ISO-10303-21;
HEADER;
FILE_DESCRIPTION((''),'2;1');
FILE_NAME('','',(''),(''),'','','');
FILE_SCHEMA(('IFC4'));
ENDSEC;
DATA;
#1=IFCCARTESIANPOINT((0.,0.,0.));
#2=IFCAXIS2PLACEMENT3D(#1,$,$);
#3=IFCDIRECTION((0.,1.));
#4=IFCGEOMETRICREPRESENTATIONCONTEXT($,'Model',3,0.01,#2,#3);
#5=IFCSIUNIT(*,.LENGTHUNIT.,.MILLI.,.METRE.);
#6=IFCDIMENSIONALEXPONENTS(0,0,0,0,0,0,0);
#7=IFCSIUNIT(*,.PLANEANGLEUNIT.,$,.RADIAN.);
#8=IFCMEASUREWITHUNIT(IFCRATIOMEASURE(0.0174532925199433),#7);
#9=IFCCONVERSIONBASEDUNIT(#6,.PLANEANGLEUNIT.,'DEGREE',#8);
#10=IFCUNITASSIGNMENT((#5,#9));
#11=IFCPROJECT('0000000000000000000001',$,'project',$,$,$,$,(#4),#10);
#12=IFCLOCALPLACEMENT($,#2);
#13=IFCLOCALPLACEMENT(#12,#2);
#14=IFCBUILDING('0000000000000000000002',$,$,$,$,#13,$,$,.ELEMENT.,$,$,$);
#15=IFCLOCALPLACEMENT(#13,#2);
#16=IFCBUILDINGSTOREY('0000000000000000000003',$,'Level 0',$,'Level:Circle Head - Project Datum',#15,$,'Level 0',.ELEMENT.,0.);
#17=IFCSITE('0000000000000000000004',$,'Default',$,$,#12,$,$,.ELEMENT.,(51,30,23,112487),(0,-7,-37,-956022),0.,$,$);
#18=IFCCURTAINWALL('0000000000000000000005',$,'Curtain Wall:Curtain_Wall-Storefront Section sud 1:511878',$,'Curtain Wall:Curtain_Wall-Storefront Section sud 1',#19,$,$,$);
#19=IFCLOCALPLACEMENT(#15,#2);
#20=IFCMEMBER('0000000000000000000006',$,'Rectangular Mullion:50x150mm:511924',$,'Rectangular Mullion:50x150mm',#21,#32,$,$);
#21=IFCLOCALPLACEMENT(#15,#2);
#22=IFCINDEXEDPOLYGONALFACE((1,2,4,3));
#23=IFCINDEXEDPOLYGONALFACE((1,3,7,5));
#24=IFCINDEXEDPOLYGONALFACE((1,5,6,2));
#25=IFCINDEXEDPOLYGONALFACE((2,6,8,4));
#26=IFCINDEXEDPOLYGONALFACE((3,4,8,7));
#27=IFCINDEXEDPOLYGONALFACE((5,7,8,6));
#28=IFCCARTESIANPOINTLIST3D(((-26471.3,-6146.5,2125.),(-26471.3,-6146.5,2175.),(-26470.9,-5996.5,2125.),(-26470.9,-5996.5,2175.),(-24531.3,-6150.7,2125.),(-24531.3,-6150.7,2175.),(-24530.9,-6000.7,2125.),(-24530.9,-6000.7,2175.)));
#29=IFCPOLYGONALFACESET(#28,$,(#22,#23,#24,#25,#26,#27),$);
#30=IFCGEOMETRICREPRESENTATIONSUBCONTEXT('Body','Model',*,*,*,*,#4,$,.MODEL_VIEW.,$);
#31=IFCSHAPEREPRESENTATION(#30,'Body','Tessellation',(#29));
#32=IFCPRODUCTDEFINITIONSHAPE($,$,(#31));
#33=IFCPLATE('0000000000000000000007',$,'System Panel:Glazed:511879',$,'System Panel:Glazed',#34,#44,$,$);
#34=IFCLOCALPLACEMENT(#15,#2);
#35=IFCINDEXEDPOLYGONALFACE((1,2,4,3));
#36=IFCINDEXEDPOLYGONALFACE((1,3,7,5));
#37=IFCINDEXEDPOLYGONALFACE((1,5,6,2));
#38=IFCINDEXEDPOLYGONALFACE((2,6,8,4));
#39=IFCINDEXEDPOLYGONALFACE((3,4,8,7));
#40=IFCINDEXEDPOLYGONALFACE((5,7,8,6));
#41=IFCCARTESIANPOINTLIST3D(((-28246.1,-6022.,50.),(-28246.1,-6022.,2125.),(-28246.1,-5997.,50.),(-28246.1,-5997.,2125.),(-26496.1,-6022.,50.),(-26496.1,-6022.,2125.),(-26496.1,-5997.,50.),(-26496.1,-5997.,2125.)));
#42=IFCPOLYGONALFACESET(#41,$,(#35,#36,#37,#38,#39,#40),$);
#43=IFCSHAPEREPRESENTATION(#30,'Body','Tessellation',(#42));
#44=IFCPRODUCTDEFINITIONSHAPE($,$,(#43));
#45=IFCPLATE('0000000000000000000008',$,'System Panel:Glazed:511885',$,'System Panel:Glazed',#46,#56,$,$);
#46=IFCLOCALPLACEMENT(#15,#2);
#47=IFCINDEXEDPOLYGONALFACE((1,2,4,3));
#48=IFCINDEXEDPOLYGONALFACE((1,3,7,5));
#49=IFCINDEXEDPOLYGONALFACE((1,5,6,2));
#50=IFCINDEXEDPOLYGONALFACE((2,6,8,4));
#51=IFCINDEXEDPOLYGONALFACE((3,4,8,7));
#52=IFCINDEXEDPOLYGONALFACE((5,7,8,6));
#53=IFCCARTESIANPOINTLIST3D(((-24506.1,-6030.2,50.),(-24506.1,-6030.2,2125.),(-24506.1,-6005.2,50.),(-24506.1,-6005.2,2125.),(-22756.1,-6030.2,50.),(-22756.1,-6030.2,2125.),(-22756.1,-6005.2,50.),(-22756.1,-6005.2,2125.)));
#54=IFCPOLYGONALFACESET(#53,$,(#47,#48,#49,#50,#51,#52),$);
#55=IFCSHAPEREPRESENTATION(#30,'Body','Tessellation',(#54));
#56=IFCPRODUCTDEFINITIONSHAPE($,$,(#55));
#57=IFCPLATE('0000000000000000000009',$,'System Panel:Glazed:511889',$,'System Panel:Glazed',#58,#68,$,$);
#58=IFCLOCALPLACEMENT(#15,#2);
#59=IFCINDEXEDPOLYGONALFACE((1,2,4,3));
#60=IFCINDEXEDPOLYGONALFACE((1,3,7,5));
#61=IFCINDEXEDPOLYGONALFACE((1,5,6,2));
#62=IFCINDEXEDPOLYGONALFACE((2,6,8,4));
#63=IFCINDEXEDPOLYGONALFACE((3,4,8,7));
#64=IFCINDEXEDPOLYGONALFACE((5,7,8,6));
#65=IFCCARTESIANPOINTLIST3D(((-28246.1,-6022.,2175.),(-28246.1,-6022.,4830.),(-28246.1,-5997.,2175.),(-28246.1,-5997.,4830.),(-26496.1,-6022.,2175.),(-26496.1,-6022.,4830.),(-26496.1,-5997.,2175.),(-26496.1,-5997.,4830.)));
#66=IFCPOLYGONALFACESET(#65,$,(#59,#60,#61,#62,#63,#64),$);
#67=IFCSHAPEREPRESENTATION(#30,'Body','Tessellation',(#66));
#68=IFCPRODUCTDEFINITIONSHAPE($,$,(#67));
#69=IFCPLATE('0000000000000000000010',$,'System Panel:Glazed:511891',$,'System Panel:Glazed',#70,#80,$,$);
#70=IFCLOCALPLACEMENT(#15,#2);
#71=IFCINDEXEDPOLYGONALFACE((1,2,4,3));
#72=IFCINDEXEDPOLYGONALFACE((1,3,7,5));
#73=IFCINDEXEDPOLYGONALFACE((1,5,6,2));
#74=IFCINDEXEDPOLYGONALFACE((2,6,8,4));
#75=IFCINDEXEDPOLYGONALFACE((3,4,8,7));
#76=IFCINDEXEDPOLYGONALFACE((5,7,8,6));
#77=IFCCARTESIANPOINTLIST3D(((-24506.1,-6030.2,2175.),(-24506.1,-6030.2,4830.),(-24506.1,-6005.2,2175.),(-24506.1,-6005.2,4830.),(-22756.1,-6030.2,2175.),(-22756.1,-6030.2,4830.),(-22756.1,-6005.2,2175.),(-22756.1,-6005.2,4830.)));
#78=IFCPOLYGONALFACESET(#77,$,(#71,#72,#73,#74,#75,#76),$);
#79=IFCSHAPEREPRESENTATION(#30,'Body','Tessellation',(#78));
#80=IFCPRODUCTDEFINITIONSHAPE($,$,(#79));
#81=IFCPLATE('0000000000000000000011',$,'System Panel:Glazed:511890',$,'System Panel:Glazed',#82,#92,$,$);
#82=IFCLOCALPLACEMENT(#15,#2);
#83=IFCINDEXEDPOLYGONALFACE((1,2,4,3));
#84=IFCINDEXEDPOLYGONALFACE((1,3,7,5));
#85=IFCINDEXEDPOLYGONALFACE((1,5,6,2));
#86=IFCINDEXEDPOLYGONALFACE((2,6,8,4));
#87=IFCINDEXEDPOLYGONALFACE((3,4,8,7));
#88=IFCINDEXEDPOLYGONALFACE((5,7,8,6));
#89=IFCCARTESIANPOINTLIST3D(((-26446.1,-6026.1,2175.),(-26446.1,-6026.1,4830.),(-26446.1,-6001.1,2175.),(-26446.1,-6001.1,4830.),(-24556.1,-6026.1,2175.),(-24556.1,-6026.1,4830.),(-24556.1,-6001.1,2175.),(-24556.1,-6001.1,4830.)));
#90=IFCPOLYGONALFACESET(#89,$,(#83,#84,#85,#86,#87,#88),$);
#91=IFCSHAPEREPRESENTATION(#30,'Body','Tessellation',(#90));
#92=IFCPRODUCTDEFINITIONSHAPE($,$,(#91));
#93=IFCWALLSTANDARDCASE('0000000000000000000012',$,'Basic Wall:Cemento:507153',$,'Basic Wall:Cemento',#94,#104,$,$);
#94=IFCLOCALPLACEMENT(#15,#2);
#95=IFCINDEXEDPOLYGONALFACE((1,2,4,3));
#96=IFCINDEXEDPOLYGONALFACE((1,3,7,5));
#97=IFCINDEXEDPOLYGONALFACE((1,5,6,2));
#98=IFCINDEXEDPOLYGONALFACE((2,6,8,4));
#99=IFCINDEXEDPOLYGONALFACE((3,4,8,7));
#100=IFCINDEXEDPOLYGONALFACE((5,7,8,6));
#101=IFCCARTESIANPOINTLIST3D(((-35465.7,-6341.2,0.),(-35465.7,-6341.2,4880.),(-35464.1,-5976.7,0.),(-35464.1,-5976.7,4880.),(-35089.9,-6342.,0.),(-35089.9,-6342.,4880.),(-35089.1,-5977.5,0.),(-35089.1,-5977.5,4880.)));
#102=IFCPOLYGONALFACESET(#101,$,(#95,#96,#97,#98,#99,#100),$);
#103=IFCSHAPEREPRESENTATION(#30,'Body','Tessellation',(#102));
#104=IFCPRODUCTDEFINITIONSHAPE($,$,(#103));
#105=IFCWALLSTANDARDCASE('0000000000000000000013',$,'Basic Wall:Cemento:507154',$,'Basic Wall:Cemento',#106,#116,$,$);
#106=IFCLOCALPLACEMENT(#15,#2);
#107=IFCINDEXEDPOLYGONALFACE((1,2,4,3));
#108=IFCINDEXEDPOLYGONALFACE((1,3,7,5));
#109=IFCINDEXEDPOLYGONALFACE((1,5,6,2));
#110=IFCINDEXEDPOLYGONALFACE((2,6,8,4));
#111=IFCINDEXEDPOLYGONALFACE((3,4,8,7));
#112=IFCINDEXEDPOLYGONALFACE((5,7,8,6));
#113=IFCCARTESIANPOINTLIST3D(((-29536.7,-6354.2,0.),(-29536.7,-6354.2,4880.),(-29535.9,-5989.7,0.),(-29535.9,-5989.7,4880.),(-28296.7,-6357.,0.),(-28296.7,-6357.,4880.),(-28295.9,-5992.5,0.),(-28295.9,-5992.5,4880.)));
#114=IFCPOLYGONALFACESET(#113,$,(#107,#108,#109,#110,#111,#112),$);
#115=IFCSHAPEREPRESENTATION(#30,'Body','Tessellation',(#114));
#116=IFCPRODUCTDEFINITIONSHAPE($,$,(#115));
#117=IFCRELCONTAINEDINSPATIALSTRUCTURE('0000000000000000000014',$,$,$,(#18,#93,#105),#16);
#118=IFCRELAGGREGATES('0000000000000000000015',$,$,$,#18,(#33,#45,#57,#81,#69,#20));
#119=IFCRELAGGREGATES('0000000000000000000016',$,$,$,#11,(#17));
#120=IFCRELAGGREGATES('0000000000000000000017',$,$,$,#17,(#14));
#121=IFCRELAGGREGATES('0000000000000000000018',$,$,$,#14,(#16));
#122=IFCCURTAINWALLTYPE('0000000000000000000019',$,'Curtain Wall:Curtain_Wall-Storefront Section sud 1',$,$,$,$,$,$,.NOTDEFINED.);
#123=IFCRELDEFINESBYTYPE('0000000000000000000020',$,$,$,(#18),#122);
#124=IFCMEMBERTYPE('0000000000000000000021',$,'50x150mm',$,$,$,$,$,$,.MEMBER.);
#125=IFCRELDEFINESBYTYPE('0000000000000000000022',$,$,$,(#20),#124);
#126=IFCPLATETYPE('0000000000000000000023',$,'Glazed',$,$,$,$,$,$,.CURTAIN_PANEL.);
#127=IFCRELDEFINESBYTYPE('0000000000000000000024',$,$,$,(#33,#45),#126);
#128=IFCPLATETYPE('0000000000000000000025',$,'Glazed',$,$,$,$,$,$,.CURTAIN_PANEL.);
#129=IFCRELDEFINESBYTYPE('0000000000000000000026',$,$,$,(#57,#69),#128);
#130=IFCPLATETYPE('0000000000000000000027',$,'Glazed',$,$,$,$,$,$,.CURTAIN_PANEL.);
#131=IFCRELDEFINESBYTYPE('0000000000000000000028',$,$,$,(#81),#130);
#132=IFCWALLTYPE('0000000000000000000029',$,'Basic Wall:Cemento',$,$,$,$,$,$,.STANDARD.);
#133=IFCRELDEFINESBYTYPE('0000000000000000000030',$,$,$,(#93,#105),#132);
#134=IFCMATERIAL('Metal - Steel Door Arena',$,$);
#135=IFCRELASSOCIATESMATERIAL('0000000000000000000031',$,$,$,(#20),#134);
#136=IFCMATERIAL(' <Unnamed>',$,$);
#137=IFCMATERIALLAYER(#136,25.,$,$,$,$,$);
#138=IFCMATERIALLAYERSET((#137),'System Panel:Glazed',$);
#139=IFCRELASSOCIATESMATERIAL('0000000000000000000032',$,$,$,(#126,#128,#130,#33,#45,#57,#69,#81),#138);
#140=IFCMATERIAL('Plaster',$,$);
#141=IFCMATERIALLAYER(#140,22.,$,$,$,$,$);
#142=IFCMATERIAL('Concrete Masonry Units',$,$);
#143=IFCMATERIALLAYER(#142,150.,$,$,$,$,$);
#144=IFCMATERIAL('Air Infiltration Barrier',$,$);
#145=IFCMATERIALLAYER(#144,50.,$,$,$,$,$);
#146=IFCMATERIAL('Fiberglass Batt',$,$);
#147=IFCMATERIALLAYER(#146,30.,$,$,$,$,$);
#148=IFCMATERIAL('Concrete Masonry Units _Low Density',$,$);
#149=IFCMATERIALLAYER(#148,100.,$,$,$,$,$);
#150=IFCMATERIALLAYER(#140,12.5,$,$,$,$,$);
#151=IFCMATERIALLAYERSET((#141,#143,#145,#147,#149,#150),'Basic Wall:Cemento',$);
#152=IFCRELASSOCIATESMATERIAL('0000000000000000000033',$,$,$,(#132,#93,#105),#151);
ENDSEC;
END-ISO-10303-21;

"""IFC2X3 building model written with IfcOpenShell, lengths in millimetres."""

from ifc_helpers import new_model, entity, si_unit, converted_unit, direction, frame, frame_2d, origin, origin_2d_with_axis, place, context, subcontext, project, spatial, polyline, rectangle, outline, extrude, source, transform, mapped, material, layer, layer_set, layer_usage, type_object, type_shapes, element, aggregate, save


model = new_model("IFC2X3")

# Units and contexts
model_context = context("Model", 3, precision=0.01, world=origin(), true_north=direction((0.0, 1.0)))
body_context = subcontext(model_context, "Body", "Model", "MODEL_VIEW")
ifc_project = project(units=[si_unit("LENGTHUNIT", "METRE", prefix="MILLI"), converted_unit("PLANEANGLEUNIT", "DEGREE", entity("IfcRatioMeasure", 0.0174532925199433), si_unit("PLANEANGLEUNIT", "RADIAN"), dimensions=[0, 0, 0, 0, 0, 0, 0])], contexts=[model_context])

# Site, building, storey
site_placement = place(None, origin())
site = spatial("IfcSite", under=ifc_project, at=site_placement, Name="Default", CompositionType="ELEMENT", RefLatitude=(51, 30, 23, 112487), RefLongitude=(0, -7, -37, -956022), RefElevation=0.0)
building_placement = place(site_placement, origin())
building = spatial("IfcBuilding", under=site, at=building_placement, CompositionType="ELEMENT")
storey_placement = place(building_placement, origin())
storey = spatial("IfcBuildingStorey", under=building, at=storey_placement, Name="Level 0", ObjectType="Level:Circle Head - Project Datum", LongName="Level 0", CompositionType="ELEMENT", Elevation=0.0)

# Shared definitions
curtain_wall_type = type_object("IfcCurtainWallType", Name="Curtain Wall:Curtain_Wall-Storefront Section sud 1", PredefinedType="NOTDEFINED")
ifc_material_1 = material(Name="Metal - Steel Door Arena")

# Curtain wall, member, plates
curtain_wall_1_placement = place(storey_placement, origin())
curtain_wall_1 = element("IfcCurtainWall", 1, at=curtain_wall_1_placement, inside=storey, type_object=curtain_wall_type, Name="Curtain Wall:Curtain_Wall-Storefront Section sud 1:511878", ObjectType="Curtain Wall:Curtain_Wall-Storefront Section sud 1")
member_type_1 = type_object("IfcMemberType", Name="50x150mm", PredefinedType="MEMBER")
shared_shape_1 = source(origin(), body_context, "Body", "SweptSolid", [
    extrude(rectangle(XDim=150.0, YDim=50.0, at=origin_2d_with_axis()), frame((0.0, 0.0, -1940.0), z_axis=(0.0, 0.0, 1.0), x_axis=(0.0, -1.0, 0.0)), (0.0, 0.0, 1.0), 1940.0),
])
type_shapes(member_type_1, [shared_shape_1])
member_1_placement = place(storey_placement, frame((-24531.1, -6075.7, 2150.0), z_axis=(0.999998, -0.002199, 0.0), x_axis=(0.0, 0.0, 1.0)))
member_1 = element("IfcMember", 2, at=member_1_placement, type_object=member_type_1, material=ifc_material_1, Name="Rectangular Mullion:50x150mm:511924", ObjectType="Rectangular Mullion:50x150mm", context=body_context, shape_type="MappedRepresentation", body=[
    mapped(shared_shape_1, transform((0.0, 0.0, 0.0), scale=1.0)),
])
ifc_material_2 = material(Name=" <Unnamed>")
ifc_layer_1 = layer(ifc_material_2, 25.0)
ifc_layer_set_1 = layer_set([ifc_layer_1], Name="System Panel:Glazed")
ifc_layer_usage_1 = layer_usage(ifc_layer_set_1, "AXIS3", "POSITIVE", 0.2)
plate_type_1 = type_object("IfcPlateType", Name="Glazed", PredefinedType="CURTAIN_PANEL", material=ifc_layer_set_1)
shared_shape_2 = source(origin(), body_context, "Body", "SweptSolid", [
    extrude(rectangle(XDim=25.0, YDim=1750.0, at=origin_2d_with_axis()), frame((0.0, 60.0, 0.0), z_axis=(0.0, 0.0, 1.0), x_axis=(0.0, 1.0, 0.0)), (0.0, 0.0, 1.0), 2075.0),
])
type_shapes(plate_type_1, [shared_shape_2])
plate_1_placement = place(curtain_wall_1_placement, frame((-27371.1, -6069.5, 50.0)))
plate_1 = element("IfcPlate", 3, at=plate_1_placement, type_object=plate_type_1, material=ifc_layer_usage_1, Name="System Panel:Glazed:511879", ObjectType="System Panel:Glazed", context=body_context, shape_type="MappedRepresentation", body=[
    mapped(shared_shape_2, transform((0.0, 0.0, 0.0), scale=1.0)),
])
ifc_layer_usage_2 = layer_usage(ifc_layer_set_1, "AXIS3", "POSITIVE", 0.2)
plate_2_placement = place(curtain_wall_1_placement, frame((-23631.1, -6077.7, 50.0)))
plate_2 = element("IfcPlate", 4, at=plate_2_placement, type_object=plate_type_1, material=ifc_layer_usage_2, Name="System Panel:Glazed:511885", ObjectType="System Panel:Glazed", context=body_context, shape_type="MappedRepresentation", body=[
    mapped(shared_shape_2, transform((0.0, 0.0, 0.0), scale=1.0)),
])
ifc_layer_usage_3 = layer_usage(ifc_layer_set_1, "AXIS3", "POSITIVE", 0.2)
plate_type_2 = type_object("IfcPlateType", Name="Glazed", PredefinedType="CURTAIN_PANEL", material=ifc_layer_set_1)
shared_shape_3 = source(origin(), body_context, "Body", "SweptSolid", [
    extrude(rectangle(XDim=25.0, YDim=1750.0, at=frame_2d((0.0, 0.0), x_axis=(1.0, 0.0))), frame((0.0, 60.0, 0.0), z_axis=(0.0, 0.0, 1.0), x_axis=(0.0, 1.0, 0.0)), (0.0, 0.0, 1.0), 2655.0),
])
type_shapes(plate_type_2, [shared_shape_3])
plate_3_placement = place(curtain_wall_1_placement, frame((-27371.1, -6069.5, 2175.0)))
plate_3 = element("IfcPlate", 5, at=plate_3_placement, type_object=plate_type_2, material=ifc_layer_usage_3, Name="System Panel:Glazed:511889", ObjectType="System Panel:Glazed", context=body_context, shape_type="MappedRepresentation", body=[
    mapped(shared_shape_3, transform((0.0, 0.0, 0.0), scale=1.0)),
])
ifc_layer_usage_4 = layer_usage(ifc_layer_set_1, "AXIS3", "POSITIVE", 0.2)
plate_4_placement = place(curtain_wall_1_placement, frame((-23631.1, -6077.7, 2175.0)))
plate_4 = element("IfcPlate", 6, at=plate_4_placement, type_object=plate_type_2, material=ifc_layer_usage_4, Name="System Panel:Glazed:511891", ObjectType="System Panel:Glazed", context=body_context, shape_type="MappedRepresentation", body=[
    mapped(shared_shape_3, transform((0.0, 0.0, 0.0), scale=1.0)),
])
ifc_layer_usage_5 = layer_usage(ifc_layer_set_1, "AXIS3", "POSITIVE", 0.2)
plate_type_3 = type_object("IfcPlateType", Name="Glazed", PredefinedType="CURTAIN_PANEL", material=ifc_layer_set_1)
shared_shape_4 = source(origin(), body_context, "Body", "SweptSolid", [
    extrude(rectangle(XDim=25.0, YDim=1890.0, at=frame_2d((0.0, 0.0), x_axis=(1.0, 0.0))), frame((0.0, 60.0, 0.0), z_axis=(0.0, 0.0, 1.0), x_axis=(0.0, 1.0, 0.0)), (0.0, 0.0, 1.0), 2655.0),
])
type_shapes(plate_type_3, [shared_shape_4])
plate_5_placement = place(curtain_wall_1_placement, frame((-25501.1, -6073.6, 2175.0)))
plate_5 = element("IfcPlate", 7, at=plate_5_placement, type_object=plate_type_3, material=ifc_layer_usage_5, Name="System Panel:Glazed:511890", ObjectType="System Panel:Glazed", context=body_context, shape_type="MappedRepresentation", body=[
    mapped(shared_shape_4, transform((0.0, 0.0, 0.0), scale=1.0)),
])
aggregate(curtain_wall_1, [plate_1, plate_2, plate_3, plate_5, plate_4, member_1])

# Walls
ifc_material_3 = material(Name="Plaster")
ifc_layer_2 = layer(ifc_material_3, 22.0)
ifc_material_4 = material(Name="Concrete Masonry Units")
ifc_layer_3 = layer(ifc_material_4, 150.0)
ifc_material_5 = material(Name="Air Infiltration Barrier")
ifc_layer_4 = layer(ifc_material_5, 50.0)
ifc_material_6 = material(Name="Fiberglass Batt")
ifc_layer_5 = layer(ifc_material_6, 30.0)
ifc_material_7 = material(Name="Concrete Masonry Units _Low Density")
ifc_layer_6 = layer(ifc_material_7, 100.0)
ifc_layer_7 = layer(ifc_material_3, 12.5)
ifc_layer_set_2 = layer_set([ifc_layer_2, ifc_layer_3, ifc_layer_4, ifc_layer_5, ifc_layer_6, ifc_layer_7], Name="Basic Wall:Cemento")
ifc_layer_usage_6 = layer_usage(ifc_layer_set_2, "AXIS2", "NEGATIVE", 182.2)
wall_type = type_object("IfcWallType", Name="Basic Wall:Cemento", PredefinedType="STANDARD", material=ifc_layer_set_2)
wall_1_placement = place(storey_placement, frame((-35089.5, -6159.8, 0.0), z_axis=(0.0, 0.0, 1.0), x_axis=(-0.999998, 0.002199, 0.0)))
element("IfcWallStandardCase", 8, at=wall_1_placement, inside=storey, type_object=wall_type, material=ifc_layer_usage_6, Name="Basic Wall:Cemento:507153", ObjectType="Basic Wall:Cemento", context=body_context, shape_type="SweptSolid", body=[
    extrude(outline(polyline([(374.9, -182.2), (375.8, 182.3), (0.0, 182.2), (0.0, -182.2), (374.9, -182.2)])), origin(), (0.0, 0.0, 1.0), 4880.0),
])
ifc_layer_usage_7 = layer_usage(ifc_layer_set_2, "AXIS2", "NEGATIVE", 182.2)
wall_2_placement = place(storey_placement, frame((-28296.3, -6174.7, 0.0), z_axis=(0.0, 0.0, 1.0), x_axis=(-0.999998, 0.002199, 0.0)))
element("IfcWallStandardCase", 9, at=wall_2_placement, inside=storey, type_object=wall_type, material=ifc_layer_usage_7, Name="Basic Wall:Cemento:507154", ObjectType="Basic Wall:Cemento", context=body_context, shape_type="SweptSolid", body=[
    extrude(rectangle(XDim=1240.0, YDim=364.5, at=frame_2d((620.0, 0.0), x_axis=(-1.0, 0.0))), origin(), (0.0, 0.0, 1.0), 4880.0),
])

save(model, "model.ifc")
